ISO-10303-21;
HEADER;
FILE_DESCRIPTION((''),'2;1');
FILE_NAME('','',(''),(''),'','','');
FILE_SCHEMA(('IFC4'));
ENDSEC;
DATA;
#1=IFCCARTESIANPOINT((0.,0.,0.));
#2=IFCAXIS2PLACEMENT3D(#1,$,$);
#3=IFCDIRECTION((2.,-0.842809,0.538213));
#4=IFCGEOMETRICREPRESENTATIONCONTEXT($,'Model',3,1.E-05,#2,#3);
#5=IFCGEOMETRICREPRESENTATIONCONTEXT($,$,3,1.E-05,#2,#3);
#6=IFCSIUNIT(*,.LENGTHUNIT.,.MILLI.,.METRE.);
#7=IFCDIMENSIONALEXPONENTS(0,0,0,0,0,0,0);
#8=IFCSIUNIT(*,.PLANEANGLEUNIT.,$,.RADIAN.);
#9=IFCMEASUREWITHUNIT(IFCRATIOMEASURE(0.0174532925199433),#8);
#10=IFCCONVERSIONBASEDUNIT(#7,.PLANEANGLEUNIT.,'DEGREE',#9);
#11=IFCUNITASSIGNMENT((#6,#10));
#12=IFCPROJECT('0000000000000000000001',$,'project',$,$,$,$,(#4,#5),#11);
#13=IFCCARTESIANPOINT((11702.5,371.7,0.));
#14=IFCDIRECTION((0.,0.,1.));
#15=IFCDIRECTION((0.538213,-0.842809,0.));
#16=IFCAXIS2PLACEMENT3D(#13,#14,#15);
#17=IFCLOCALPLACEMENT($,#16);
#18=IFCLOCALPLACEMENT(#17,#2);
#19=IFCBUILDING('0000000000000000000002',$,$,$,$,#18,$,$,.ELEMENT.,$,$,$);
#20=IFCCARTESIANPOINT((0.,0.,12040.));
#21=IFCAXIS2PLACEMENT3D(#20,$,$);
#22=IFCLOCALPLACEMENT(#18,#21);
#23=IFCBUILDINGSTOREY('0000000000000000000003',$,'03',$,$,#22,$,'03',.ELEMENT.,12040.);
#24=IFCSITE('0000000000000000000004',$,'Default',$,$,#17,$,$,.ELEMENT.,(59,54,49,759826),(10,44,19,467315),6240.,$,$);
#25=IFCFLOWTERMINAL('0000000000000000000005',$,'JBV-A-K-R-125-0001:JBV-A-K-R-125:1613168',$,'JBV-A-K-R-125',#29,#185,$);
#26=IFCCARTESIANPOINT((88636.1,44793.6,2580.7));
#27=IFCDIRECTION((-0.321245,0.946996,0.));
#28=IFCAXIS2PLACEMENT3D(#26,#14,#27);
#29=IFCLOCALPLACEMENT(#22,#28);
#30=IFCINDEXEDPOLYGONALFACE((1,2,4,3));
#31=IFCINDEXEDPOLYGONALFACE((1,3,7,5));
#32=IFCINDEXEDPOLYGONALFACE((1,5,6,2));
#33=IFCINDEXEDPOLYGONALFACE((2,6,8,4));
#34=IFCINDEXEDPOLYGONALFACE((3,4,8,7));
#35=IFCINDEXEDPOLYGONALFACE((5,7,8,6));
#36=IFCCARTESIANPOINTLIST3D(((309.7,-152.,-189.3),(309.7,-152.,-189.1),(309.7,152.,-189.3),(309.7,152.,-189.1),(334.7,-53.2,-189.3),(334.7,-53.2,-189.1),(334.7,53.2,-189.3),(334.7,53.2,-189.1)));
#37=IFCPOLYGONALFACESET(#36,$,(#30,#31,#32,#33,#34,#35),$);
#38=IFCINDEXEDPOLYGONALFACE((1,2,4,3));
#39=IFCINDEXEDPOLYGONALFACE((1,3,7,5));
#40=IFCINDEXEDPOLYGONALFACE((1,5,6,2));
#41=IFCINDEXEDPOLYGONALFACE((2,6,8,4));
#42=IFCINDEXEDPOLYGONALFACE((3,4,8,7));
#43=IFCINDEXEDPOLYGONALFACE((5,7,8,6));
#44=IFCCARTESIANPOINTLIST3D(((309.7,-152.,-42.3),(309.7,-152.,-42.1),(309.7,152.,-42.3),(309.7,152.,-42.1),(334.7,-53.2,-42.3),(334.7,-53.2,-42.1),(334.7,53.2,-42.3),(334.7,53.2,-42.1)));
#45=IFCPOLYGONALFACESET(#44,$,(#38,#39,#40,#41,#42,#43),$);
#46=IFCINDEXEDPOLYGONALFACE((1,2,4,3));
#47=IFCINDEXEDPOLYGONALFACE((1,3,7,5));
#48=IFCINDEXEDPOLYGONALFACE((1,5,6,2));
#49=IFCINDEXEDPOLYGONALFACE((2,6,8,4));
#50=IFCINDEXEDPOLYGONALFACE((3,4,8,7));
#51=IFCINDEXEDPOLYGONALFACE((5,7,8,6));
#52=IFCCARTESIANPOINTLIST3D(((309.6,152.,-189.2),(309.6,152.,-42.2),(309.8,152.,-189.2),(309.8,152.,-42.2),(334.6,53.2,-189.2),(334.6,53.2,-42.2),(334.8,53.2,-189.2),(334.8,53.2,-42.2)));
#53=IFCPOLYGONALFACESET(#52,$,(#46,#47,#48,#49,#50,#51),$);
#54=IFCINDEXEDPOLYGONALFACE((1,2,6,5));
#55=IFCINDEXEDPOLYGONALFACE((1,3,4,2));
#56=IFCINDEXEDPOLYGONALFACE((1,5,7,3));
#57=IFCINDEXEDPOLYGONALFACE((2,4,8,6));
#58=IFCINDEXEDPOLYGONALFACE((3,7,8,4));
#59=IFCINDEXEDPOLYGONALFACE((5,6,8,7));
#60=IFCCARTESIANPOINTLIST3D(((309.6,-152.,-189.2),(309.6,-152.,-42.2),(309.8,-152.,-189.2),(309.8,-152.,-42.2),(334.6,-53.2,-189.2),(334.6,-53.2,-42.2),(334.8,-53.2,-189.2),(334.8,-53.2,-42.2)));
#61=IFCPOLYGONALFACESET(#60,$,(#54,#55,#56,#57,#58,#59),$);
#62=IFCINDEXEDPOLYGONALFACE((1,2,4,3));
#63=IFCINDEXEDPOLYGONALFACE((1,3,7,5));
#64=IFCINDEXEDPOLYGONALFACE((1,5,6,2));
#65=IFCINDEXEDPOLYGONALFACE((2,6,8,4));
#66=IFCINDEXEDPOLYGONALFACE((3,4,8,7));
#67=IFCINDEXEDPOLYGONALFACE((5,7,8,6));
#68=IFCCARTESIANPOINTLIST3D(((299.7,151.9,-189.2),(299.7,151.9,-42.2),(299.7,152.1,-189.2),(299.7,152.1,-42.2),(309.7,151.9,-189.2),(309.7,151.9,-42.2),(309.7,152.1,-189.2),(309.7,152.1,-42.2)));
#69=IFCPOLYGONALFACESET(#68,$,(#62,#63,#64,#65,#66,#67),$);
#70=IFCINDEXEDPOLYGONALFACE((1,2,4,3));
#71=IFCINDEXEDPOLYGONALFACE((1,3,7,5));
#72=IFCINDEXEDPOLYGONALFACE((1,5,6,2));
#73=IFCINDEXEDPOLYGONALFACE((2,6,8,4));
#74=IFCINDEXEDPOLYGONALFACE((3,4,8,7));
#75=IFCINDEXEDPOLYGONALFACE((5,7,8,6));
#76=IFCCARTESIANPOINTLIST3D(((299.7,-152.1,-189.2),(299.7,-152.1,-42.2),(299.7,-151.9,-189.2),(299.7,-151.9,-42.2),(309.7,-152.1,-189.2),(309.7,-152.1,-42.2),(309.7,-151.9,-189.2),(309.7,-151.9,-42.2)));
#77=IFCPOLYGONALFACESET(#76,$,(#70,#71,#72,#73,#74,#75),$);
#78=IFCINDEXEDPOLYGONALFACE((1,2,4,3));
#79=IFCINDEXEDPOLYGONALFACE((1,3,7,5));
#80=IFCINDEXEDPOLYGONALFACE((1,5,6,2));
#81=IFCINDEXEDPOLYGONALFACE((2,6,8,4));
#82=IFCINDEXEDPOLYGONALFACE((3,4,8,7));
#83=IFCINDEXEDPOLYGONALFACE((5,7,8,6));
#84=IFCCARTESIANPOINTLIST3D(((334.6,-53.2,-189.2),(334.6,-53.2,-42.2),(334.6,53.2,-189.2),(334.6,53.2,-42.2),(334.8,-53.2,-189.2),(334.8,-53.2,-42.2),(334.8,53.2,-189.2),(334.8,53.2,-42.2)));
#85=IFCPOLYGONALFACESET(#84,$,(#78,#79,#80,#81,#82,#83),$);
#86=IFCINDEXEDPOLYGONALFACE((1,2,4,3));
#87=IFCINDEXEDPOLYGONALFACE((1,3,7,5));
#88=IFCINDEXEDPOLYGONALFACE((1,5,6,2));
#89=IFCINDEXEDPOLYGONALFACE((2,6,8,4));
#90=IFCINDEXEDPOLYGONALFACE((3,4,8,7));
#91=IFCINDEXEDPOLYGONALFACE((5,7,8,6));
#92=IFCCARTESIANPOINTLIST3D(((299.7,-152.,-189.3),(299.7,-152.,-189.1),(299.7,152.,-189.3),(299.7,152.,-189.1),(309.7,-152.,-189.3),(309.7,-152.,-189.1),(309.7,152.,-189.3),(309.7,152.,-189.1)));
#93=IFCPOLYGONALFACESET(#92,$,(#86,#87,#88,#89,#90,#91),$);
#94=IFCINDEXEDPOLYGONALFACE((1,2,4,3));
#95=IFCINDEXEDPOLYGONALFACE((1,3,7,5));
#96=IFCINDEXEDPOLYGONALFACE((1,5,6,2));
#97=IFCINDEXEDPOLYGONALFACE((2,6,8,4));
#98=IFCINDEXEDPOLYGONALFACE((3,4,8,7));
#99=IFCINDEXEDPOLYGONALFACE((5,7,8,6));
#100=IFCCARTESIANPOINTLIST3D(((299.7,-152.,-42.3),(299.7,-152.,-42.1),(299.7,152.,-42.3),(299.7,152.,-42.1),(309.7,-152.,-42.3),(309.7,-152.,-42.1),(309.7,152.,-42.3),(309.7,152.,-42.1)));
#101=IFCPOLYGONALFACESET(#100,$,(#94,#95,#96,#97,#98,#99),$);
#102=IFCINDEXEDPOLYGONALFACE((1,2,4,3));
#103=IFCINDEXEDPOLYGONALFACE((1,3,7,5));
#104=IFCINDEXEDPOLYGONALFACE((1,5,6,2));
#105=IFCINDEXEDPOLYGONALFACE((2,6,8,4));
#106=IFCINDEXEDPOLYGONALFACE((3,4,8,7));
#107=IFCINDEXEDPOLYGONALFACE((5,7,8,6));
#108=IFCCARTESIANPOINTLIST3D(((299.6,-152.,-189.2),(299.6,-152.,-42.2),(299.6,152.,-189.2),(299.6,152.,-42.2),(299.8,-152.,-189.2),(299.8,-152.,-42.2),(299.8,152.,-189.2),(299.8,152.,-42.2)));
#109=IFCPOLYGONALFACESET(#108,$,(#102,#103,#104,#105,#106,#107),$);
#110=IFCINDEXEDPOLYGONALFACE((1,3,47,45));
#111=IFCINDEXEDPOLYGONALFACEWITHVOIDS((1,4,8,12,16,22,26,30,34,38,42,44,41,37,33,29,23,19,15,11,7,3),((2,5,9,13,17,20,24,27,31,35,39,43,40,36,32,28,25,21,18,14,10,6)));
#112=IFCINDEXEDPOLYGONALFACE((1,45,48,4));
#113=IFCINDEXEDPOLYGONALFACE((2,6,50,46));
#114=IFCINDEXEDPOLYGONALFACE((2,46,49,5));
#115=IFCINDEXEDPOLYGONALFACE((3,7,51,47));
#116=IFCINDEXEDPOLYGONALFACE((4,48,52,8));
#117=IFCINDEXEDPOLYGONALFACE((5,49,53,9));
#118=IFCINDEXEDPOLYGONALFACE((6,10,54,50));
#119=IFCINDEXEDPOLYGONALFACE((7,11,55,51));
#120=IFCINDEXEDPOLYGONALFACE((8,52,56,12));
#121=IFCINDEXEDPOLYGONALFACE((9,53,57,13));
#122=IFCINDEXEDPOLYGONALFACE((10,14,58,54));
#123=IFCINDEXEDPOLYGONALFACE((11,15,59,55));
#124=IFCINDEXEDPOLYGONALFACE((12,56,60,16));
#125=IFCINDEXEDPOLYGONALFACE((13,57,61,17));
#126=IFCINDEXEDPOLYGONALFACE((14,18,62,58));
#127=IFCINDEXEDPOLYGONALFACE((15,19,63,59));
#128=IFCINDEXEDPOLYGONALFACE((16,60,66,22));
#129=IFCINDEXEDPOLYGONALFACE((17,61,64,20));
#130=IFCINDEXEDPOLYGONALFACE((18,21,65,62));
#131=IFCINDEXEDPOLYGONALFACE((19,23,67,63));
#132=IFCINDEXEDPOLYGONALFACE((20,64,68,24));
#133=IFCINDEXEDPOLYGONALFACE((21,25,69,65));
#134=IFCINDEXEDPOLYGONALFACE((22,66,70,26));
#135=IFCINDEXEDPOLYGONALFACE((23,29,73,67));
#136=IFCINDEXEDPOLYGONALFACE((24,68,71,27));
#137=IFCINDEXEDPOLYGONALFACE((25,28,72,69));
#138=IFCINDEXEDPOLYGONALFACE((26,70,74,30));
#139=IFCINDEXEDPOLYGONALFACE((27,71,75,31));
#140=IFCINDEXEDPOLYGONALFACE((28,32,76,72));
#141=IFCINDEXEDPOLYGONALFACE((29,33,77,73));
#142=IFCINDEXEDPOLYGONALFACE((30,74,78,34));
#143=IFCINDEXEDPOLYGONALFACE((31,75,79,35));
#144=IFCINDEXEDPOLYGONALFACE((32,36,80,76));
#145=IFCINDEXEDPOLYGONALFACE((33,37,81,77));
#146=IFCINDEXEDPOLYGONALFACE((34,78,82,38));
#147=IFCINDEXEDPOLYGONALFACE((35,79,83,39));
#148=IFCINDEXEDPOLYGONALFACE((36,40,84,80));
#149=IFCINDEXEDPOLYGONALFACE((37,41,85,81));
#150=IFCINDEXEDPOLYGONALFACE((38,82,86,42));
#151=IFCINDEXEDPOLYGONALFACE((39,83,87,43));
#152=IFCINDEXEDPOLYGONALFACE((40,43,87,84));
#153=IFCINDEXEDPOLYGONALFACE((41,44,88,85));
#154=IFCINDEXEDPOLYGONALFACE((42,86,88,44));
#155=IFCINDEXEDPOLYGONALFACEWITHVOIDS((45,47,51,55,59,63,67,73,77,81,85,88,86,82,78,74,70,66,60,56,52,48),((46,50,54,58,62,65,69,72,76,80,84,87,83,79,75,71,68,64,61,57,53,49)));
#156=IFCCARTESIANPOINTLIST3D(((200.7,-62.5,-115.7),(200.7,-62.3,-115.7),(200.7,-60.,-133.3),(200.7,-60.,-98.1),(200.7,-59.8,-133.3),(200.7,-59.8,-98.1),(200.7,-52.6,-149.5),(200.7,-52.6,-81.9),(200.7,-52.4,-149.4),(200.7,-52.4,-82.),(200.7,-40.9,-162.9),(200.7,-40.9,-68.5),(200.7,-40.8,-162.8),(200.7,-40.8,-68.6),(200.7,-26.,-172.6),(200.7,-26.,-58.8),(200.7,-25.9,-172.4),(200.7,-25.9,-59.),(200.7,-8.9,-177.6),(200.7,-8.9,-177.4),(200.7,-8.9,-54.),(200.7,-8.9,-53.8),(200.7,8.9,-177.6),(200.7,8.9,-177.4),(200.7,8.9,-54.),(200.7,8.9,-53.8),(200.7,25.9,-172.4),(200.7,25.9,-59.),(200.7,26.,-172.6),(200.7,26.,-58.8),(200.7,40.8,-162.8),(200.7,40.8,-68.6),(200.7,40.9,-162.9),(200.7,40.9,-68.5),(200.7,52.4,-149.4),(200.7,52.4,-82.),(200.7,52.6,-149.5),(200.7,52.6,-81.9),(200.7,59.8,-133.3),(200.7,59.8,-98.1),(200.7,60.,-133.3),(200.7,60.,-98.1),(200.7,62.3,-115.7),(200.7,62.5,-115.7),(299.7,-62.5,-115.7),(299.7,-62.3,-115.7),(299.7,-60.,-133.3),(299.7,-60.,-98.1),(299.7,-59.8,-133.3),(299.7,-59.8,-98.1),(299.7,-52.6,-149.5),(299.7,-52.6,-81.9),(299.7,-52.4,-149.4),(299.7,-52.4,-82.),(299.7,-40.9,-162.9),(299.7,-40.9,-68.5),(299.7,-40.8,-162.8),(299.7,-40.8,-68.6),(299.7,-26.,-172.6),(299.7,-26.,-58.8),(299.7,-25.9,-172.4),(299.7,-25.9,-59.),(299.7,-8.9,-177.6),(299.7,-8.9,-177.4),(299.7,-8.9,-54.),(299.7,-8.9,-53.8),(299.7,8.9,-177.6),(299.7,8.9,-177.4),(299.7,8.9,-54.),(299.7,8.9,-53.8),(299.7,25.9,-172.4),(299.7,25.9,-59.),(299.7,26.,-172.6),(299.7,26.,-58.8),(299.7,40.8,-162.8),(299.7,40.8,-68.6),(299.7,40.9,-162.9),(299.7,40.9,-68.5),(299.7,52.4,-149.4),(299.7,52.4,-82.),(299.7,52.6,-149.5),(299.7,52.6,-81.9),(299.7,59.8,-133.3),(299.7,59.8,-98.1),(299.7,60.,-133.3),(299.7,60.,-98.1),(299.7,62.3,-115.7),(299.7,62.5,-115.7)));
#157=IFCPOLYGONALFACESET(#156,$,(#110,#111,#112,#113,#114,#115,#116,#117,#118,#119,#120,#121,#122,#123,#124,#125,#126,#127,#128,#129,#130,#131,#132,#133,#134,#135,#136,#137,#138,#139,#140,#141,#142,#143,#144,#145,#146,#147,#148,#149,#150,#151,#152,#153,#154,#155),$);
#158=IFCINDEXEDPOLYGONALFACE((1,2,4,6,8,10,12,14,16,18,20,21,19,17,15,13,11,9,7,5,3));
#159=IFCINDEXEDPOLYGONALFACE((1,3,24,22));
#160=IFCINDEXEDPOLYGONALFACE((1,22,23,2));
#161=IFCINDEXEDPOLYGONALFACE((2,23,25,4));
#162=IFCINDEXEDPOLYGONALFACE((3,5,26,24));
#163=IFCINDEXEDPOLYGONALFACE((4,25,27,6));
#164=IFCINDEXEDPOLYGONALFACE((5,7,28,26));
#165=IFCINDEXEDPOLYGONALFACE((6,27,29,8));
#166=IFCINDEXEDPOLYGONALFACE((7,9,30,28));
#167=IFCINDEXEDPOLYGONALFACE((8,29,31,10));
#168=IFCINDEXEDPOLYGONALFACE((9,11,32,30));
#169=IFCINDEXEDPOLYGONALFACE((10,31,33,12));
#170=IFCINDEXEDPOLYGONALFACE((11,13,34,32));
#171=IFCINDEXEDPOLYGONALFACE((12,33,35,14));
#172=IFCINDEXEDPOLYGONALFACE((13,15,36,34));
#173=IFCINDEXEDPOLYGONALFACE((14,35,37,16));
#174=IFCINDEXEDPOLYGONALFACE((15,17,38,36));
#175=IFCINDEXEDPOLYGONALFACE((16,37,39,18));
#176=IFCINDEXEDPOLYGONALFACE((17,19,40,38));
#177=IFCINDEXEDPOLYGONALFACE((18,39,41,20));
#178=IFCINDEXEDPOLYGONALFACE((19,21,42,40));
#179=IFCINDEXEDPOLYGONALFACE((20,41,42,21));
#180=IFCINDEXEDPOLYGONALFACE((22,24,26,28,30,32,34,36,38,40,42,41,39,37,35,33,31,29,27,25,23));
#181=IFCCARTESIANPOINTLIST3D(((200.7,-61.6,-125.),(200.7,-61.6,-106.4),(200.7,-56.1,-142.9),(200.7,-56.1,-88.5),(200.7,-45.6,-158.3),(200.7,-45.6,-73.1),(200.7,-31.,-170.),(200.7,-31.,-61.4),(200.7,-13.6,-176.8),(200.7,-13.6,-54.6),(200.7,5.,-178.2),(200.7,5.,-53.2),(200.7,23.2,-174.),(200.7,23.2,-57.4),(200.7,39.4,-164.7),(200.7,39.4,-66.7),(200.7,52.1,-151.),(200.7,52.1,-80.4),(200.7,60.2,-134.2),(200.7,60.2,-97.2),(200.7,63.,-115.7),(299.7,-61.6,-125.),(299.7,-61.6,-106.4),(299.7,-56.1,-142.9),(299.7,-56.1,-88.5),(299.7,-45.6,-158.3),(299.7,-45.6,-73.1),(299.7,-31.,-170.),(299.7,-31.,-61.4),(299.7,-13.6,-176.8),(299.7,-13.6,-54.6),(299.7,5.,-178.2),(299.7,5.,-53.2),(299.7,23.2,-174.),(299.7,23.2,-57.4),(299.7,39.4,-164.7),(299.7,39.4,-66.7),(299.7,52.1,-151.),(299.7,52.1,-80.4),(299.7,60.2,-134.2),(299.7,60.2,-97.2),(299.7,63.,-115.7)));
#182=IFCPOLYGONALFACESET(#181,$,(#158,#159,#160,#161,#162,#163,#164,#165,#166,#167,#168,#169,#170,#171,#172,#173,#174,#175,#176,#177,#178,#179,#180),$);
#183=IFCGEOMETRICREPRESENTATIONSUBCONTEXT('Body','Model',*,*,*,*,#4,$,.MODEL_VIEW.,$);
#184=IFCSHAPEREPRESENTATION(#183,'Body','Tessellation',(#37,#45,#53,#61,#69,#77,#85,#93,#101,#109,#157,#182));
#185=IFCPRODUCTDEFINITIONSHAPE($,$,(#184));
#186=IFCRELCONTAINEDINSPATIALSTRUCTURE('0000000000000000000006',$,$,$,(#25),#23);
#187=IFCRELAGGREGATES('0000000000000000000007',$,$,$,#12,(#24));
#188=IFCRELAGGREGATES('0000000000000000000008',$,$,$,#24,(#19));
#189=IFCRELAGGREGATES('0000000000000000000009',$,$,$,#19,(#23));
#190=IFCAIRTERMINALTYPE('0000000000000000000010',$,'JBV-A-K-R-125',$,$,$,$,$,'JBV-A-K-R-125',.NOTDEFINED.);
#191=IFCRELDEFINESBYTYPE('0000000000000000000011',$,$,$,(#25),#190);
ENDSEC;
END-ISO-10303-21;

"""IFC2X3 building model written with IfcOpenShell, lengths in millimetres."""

from ifc_helpers import new_model, entity, si_unit, converted_unit, direction, frame, frame_2d, origin, origin_2d_with_axis, place, context, subcontext, project, spatial, polyline, circle_curve, parameter, trimmed, segment, composite_curve, rectangle, circle, outline, extrude, source, transform, mapped, type_object, type_shapes, element, save


model = new_model("IFC2X3")

# Units and contexts
model_context = context("Model", 3, precision=1e-05, world=origin(), true_north=direction((2.0, -0.842809, 0.538213)))
context_of_model = context(None, 3, precision=1e-05, world=origin(), true_north=direction((2.0, -0.842809, 0.538213)))
body_context = subcontext(model_context, "Body", "Model", "MODEL_VIEW")
ifc_project = project(units=[si_unit("LENGTHUNIT", "METRE", prefix="MILLI"), converted_unit("PLANEANGLEUNIT", "DEGREE", entity("IfcRatioMeasure", 0.0174532925199433), si_unit("PLANEANGLEUNIT", "RADIAN"), dimensions=[0, 0, 0, 0, 0, 0, 0])], contexts=[model_context, context_of_model])

# Site, building, storey
site_placement = place(None, frame((11702.5, 371.7, 0.0), z_axis=(0.0, 0.0, 1.0), x_axis=(0.538213, -0.842809, 0.0)))
site = spatial("IfcSite", under=ifc_project, at=site_placement, Name="Default", CompositionType="ELEMENT", RefLatitude=(59, 54, 49, 759826), RefLongitude=(10, 44, 19, 467315), RefElevation=6240.0)
building_placement = place(site_placement, origin())
building = spatial("IfcBuilding", under=site, at=building_placement, CompositionType="ELEMENT")
storey_placement = place(building_placement, frame((0.0, 0.0, 12040.0)))
storey = spatial("IfcBuildingStorey", under=building, at=storey_placement, Name="03", LongName="03", CompositionType="ELEMENT", Elevation=12040.0)

# Flow terminal
air_terminal_type_1 = type_object("IfcAirTerminalType", Name="JBV-A-K-R-125", ElementType="JBV-A-K-R-125", PredefinedType="NOTDEFINED")
shared_shape_1 = source(origin(), body_context, "Body", "SweptSolid", [
    extrude(outline(polyline([(-152.0, -12.5), (152.0, -12.5), (53.2, 12.5), (-53.2, 12.5), (-152.0, -12.5)])), frame((322.2, 0.0, -189.3), z_axis=(0.0, 0.0, 1.0), x_axis=(0.0, -1.0, 0.0)), (0.0, 0.0, 1.0), 0.2),
    extrude(outline(polyline([(-152.0, -12.5), (152.0, -12.5), (53.2, 12.5), (-53.2, 12.5), (-152.0, -12.5)])), frame((322.2, 0.0, -42.3), z_axis=(0.0, 0.0, 1.0), x_axis=(0.0, -1.0, 0.0)), (0.0, 0.0, 1.0), 0.2),
    extrude(rectangle(XDim=0.2, YDim=101.9, at=frame_2d((0.0, 0.0), x_axis=(1.0, 0.0))), frame((322.2, 102.6, -189.2), z_axis=(0.0, 0.0, 1.0), x_axis=(0.969446, 0.245305, 0.0)), (0.0, 0.0, 1.0), 147.0),
    extrude(rectangle(XDim=0.2, YDim=101.9, at=frame_2d((0.0, 0.0), x_axis=(1.0, 0.0))), frame((322.2, -102.6, -189.2), z_axis=(0.0, 0.0, 1.0), x_axis=(-0.969446, 0.245305, 0.0)), (0.0, 0.0, 1.0), 147.0),
    extrude(rectangle(XDim=0.2, YDim=10.0, at=frame_2d((0.0, 0.0), x_axis=(1.0, 0.0))), frame((304.7, 152.0, -189.2), z_axis=(0.0, 0.0, 1.0), x_axis=(0.0, 1.0, 0.0)), (0.0, 0.0, 1.0), 147.0),
    extrude(rectangle(XDim=0.2, YDim=10.0, at=frame_2d((0.0, 0.0), x_axis=(1.0, 0.0))), frame((304.7, -152.0, -189.2), z_axis=(0.0, 0.0, 1.0), x_axis=(0.0, 1.0, 0.0)), (0.0, 0.0, 1.0), 147.0),
    extrude(rectangle(XDim=0.2, YDim=106.4, at=frame_2d((0.0, 0.0), x_axis=(1.0, 0.0))), frame((334.7, 0.0, -189.2)), (0.0, 0.0, 1.0), 147.0),
    extrude(rectangle(XDim=304.0, YDim=10.0, at=frame_2d((0.0, 0.0), x_axis=(1.0, 0.0))), frame((304.7, 0.0, -189.3), z_axis=(0.0, 0.0, 1.0), x_axis=(0.0, -1.0, 0.0)), (0.0, 0.0, 1.0), 0.2),
    extrude(rectangle(XDim=304.0, YDim=10.0, at=frame_2d((0.0, 0.0), x_axis=(1.0, 0.0))), frame((304.7, 0.0, -42.3), z_axis=(0.0, 0.0, 1.0), x_axis=(0.0, -1.0, 0.0)), (0.0, 0.0, 1.0), 0.2),
    extrude(rectangle(XDim=0.2, YDim=304.0, at=frame_2d((0.0, 0.0), x_axis=(1.0, 0.0))), frame((299.7, 0.0, -189.2)), (0.0, 0.0, 1.0), 147.0),
    extrude(outline(composite_curve([segment(trimmed(circle_curve(origin_2d_with_axis(), 62.5), [parameter(0.0)], [parameter(180.0)], True, "PARAMETER"), True, "CONTINUOUS"), segment(trimmed(circle_curve(origin_2d_with_axis(), 62.5), [parameter(180.0)], [parameter(360.0)], True, "PARAMETER"), True, "CONTINUOUS")], self_intersect=False), holes=[composite_curve([segment(trimmed(circle_curve(origin_2d_with_axis(), 62.3), [parameter(180.0)], [parameter(360.0)], True, "PARAMETER"), False, "CONTINUOUS"), segment(trimmed(circle_curve(origin_2d_with_axis(), 62.3), [parameter(0.0)], [parameter(180.0)], True, "PARAMETER"), False, "CONTINUOUS")], self_intersect=False)]), frame((200.7, 0.0, -115.7), z_axis=(1.0, 0.0, 0.0), x_axis=(0.0, 1.0, 0.0)), (0.0, 0.0, 1.0), 99.0),
    extrude(circle(Radius=62.6, at=frame_2d((0.0, 0.0), x_axis=(1.0, 0.0))), frame((200.7, 0.3, -115.7), z_axis=(1.0, 0.0, 0.0), x_axis=(0.0, 1.0, 0.0)), (0.0, 0.0, 1.0), 99.0),
])
type_shapes(air_terminal_type_1, [shared_shape_1])
for number, where, z_axis, x_axis, name in (
    (1, (88636.1, 44793.6, 2580.7), (0.0, 0.0, 1.0), (-0.321245, 0.946996, 0.0), "JBV-A-K-R-125-0001:JBV-A-K-R-125:1613168"),
):
    element("IfcFlowTerminal", number, at=place(storey_placement, frame(where, z_axis=z_axis, x_axis=x_axis)), inside=storey, type_object=air_terminal_type_1, Name=name, ObjectType="JBV-A-K-R-125", context=body_context, shape_type="MappedRepresentation", body=[
        mapped(shared_shape_1, transform((0.0, 0.0, 0.0), scale=1.0)),
    ])

save(model, "model.ifc")
